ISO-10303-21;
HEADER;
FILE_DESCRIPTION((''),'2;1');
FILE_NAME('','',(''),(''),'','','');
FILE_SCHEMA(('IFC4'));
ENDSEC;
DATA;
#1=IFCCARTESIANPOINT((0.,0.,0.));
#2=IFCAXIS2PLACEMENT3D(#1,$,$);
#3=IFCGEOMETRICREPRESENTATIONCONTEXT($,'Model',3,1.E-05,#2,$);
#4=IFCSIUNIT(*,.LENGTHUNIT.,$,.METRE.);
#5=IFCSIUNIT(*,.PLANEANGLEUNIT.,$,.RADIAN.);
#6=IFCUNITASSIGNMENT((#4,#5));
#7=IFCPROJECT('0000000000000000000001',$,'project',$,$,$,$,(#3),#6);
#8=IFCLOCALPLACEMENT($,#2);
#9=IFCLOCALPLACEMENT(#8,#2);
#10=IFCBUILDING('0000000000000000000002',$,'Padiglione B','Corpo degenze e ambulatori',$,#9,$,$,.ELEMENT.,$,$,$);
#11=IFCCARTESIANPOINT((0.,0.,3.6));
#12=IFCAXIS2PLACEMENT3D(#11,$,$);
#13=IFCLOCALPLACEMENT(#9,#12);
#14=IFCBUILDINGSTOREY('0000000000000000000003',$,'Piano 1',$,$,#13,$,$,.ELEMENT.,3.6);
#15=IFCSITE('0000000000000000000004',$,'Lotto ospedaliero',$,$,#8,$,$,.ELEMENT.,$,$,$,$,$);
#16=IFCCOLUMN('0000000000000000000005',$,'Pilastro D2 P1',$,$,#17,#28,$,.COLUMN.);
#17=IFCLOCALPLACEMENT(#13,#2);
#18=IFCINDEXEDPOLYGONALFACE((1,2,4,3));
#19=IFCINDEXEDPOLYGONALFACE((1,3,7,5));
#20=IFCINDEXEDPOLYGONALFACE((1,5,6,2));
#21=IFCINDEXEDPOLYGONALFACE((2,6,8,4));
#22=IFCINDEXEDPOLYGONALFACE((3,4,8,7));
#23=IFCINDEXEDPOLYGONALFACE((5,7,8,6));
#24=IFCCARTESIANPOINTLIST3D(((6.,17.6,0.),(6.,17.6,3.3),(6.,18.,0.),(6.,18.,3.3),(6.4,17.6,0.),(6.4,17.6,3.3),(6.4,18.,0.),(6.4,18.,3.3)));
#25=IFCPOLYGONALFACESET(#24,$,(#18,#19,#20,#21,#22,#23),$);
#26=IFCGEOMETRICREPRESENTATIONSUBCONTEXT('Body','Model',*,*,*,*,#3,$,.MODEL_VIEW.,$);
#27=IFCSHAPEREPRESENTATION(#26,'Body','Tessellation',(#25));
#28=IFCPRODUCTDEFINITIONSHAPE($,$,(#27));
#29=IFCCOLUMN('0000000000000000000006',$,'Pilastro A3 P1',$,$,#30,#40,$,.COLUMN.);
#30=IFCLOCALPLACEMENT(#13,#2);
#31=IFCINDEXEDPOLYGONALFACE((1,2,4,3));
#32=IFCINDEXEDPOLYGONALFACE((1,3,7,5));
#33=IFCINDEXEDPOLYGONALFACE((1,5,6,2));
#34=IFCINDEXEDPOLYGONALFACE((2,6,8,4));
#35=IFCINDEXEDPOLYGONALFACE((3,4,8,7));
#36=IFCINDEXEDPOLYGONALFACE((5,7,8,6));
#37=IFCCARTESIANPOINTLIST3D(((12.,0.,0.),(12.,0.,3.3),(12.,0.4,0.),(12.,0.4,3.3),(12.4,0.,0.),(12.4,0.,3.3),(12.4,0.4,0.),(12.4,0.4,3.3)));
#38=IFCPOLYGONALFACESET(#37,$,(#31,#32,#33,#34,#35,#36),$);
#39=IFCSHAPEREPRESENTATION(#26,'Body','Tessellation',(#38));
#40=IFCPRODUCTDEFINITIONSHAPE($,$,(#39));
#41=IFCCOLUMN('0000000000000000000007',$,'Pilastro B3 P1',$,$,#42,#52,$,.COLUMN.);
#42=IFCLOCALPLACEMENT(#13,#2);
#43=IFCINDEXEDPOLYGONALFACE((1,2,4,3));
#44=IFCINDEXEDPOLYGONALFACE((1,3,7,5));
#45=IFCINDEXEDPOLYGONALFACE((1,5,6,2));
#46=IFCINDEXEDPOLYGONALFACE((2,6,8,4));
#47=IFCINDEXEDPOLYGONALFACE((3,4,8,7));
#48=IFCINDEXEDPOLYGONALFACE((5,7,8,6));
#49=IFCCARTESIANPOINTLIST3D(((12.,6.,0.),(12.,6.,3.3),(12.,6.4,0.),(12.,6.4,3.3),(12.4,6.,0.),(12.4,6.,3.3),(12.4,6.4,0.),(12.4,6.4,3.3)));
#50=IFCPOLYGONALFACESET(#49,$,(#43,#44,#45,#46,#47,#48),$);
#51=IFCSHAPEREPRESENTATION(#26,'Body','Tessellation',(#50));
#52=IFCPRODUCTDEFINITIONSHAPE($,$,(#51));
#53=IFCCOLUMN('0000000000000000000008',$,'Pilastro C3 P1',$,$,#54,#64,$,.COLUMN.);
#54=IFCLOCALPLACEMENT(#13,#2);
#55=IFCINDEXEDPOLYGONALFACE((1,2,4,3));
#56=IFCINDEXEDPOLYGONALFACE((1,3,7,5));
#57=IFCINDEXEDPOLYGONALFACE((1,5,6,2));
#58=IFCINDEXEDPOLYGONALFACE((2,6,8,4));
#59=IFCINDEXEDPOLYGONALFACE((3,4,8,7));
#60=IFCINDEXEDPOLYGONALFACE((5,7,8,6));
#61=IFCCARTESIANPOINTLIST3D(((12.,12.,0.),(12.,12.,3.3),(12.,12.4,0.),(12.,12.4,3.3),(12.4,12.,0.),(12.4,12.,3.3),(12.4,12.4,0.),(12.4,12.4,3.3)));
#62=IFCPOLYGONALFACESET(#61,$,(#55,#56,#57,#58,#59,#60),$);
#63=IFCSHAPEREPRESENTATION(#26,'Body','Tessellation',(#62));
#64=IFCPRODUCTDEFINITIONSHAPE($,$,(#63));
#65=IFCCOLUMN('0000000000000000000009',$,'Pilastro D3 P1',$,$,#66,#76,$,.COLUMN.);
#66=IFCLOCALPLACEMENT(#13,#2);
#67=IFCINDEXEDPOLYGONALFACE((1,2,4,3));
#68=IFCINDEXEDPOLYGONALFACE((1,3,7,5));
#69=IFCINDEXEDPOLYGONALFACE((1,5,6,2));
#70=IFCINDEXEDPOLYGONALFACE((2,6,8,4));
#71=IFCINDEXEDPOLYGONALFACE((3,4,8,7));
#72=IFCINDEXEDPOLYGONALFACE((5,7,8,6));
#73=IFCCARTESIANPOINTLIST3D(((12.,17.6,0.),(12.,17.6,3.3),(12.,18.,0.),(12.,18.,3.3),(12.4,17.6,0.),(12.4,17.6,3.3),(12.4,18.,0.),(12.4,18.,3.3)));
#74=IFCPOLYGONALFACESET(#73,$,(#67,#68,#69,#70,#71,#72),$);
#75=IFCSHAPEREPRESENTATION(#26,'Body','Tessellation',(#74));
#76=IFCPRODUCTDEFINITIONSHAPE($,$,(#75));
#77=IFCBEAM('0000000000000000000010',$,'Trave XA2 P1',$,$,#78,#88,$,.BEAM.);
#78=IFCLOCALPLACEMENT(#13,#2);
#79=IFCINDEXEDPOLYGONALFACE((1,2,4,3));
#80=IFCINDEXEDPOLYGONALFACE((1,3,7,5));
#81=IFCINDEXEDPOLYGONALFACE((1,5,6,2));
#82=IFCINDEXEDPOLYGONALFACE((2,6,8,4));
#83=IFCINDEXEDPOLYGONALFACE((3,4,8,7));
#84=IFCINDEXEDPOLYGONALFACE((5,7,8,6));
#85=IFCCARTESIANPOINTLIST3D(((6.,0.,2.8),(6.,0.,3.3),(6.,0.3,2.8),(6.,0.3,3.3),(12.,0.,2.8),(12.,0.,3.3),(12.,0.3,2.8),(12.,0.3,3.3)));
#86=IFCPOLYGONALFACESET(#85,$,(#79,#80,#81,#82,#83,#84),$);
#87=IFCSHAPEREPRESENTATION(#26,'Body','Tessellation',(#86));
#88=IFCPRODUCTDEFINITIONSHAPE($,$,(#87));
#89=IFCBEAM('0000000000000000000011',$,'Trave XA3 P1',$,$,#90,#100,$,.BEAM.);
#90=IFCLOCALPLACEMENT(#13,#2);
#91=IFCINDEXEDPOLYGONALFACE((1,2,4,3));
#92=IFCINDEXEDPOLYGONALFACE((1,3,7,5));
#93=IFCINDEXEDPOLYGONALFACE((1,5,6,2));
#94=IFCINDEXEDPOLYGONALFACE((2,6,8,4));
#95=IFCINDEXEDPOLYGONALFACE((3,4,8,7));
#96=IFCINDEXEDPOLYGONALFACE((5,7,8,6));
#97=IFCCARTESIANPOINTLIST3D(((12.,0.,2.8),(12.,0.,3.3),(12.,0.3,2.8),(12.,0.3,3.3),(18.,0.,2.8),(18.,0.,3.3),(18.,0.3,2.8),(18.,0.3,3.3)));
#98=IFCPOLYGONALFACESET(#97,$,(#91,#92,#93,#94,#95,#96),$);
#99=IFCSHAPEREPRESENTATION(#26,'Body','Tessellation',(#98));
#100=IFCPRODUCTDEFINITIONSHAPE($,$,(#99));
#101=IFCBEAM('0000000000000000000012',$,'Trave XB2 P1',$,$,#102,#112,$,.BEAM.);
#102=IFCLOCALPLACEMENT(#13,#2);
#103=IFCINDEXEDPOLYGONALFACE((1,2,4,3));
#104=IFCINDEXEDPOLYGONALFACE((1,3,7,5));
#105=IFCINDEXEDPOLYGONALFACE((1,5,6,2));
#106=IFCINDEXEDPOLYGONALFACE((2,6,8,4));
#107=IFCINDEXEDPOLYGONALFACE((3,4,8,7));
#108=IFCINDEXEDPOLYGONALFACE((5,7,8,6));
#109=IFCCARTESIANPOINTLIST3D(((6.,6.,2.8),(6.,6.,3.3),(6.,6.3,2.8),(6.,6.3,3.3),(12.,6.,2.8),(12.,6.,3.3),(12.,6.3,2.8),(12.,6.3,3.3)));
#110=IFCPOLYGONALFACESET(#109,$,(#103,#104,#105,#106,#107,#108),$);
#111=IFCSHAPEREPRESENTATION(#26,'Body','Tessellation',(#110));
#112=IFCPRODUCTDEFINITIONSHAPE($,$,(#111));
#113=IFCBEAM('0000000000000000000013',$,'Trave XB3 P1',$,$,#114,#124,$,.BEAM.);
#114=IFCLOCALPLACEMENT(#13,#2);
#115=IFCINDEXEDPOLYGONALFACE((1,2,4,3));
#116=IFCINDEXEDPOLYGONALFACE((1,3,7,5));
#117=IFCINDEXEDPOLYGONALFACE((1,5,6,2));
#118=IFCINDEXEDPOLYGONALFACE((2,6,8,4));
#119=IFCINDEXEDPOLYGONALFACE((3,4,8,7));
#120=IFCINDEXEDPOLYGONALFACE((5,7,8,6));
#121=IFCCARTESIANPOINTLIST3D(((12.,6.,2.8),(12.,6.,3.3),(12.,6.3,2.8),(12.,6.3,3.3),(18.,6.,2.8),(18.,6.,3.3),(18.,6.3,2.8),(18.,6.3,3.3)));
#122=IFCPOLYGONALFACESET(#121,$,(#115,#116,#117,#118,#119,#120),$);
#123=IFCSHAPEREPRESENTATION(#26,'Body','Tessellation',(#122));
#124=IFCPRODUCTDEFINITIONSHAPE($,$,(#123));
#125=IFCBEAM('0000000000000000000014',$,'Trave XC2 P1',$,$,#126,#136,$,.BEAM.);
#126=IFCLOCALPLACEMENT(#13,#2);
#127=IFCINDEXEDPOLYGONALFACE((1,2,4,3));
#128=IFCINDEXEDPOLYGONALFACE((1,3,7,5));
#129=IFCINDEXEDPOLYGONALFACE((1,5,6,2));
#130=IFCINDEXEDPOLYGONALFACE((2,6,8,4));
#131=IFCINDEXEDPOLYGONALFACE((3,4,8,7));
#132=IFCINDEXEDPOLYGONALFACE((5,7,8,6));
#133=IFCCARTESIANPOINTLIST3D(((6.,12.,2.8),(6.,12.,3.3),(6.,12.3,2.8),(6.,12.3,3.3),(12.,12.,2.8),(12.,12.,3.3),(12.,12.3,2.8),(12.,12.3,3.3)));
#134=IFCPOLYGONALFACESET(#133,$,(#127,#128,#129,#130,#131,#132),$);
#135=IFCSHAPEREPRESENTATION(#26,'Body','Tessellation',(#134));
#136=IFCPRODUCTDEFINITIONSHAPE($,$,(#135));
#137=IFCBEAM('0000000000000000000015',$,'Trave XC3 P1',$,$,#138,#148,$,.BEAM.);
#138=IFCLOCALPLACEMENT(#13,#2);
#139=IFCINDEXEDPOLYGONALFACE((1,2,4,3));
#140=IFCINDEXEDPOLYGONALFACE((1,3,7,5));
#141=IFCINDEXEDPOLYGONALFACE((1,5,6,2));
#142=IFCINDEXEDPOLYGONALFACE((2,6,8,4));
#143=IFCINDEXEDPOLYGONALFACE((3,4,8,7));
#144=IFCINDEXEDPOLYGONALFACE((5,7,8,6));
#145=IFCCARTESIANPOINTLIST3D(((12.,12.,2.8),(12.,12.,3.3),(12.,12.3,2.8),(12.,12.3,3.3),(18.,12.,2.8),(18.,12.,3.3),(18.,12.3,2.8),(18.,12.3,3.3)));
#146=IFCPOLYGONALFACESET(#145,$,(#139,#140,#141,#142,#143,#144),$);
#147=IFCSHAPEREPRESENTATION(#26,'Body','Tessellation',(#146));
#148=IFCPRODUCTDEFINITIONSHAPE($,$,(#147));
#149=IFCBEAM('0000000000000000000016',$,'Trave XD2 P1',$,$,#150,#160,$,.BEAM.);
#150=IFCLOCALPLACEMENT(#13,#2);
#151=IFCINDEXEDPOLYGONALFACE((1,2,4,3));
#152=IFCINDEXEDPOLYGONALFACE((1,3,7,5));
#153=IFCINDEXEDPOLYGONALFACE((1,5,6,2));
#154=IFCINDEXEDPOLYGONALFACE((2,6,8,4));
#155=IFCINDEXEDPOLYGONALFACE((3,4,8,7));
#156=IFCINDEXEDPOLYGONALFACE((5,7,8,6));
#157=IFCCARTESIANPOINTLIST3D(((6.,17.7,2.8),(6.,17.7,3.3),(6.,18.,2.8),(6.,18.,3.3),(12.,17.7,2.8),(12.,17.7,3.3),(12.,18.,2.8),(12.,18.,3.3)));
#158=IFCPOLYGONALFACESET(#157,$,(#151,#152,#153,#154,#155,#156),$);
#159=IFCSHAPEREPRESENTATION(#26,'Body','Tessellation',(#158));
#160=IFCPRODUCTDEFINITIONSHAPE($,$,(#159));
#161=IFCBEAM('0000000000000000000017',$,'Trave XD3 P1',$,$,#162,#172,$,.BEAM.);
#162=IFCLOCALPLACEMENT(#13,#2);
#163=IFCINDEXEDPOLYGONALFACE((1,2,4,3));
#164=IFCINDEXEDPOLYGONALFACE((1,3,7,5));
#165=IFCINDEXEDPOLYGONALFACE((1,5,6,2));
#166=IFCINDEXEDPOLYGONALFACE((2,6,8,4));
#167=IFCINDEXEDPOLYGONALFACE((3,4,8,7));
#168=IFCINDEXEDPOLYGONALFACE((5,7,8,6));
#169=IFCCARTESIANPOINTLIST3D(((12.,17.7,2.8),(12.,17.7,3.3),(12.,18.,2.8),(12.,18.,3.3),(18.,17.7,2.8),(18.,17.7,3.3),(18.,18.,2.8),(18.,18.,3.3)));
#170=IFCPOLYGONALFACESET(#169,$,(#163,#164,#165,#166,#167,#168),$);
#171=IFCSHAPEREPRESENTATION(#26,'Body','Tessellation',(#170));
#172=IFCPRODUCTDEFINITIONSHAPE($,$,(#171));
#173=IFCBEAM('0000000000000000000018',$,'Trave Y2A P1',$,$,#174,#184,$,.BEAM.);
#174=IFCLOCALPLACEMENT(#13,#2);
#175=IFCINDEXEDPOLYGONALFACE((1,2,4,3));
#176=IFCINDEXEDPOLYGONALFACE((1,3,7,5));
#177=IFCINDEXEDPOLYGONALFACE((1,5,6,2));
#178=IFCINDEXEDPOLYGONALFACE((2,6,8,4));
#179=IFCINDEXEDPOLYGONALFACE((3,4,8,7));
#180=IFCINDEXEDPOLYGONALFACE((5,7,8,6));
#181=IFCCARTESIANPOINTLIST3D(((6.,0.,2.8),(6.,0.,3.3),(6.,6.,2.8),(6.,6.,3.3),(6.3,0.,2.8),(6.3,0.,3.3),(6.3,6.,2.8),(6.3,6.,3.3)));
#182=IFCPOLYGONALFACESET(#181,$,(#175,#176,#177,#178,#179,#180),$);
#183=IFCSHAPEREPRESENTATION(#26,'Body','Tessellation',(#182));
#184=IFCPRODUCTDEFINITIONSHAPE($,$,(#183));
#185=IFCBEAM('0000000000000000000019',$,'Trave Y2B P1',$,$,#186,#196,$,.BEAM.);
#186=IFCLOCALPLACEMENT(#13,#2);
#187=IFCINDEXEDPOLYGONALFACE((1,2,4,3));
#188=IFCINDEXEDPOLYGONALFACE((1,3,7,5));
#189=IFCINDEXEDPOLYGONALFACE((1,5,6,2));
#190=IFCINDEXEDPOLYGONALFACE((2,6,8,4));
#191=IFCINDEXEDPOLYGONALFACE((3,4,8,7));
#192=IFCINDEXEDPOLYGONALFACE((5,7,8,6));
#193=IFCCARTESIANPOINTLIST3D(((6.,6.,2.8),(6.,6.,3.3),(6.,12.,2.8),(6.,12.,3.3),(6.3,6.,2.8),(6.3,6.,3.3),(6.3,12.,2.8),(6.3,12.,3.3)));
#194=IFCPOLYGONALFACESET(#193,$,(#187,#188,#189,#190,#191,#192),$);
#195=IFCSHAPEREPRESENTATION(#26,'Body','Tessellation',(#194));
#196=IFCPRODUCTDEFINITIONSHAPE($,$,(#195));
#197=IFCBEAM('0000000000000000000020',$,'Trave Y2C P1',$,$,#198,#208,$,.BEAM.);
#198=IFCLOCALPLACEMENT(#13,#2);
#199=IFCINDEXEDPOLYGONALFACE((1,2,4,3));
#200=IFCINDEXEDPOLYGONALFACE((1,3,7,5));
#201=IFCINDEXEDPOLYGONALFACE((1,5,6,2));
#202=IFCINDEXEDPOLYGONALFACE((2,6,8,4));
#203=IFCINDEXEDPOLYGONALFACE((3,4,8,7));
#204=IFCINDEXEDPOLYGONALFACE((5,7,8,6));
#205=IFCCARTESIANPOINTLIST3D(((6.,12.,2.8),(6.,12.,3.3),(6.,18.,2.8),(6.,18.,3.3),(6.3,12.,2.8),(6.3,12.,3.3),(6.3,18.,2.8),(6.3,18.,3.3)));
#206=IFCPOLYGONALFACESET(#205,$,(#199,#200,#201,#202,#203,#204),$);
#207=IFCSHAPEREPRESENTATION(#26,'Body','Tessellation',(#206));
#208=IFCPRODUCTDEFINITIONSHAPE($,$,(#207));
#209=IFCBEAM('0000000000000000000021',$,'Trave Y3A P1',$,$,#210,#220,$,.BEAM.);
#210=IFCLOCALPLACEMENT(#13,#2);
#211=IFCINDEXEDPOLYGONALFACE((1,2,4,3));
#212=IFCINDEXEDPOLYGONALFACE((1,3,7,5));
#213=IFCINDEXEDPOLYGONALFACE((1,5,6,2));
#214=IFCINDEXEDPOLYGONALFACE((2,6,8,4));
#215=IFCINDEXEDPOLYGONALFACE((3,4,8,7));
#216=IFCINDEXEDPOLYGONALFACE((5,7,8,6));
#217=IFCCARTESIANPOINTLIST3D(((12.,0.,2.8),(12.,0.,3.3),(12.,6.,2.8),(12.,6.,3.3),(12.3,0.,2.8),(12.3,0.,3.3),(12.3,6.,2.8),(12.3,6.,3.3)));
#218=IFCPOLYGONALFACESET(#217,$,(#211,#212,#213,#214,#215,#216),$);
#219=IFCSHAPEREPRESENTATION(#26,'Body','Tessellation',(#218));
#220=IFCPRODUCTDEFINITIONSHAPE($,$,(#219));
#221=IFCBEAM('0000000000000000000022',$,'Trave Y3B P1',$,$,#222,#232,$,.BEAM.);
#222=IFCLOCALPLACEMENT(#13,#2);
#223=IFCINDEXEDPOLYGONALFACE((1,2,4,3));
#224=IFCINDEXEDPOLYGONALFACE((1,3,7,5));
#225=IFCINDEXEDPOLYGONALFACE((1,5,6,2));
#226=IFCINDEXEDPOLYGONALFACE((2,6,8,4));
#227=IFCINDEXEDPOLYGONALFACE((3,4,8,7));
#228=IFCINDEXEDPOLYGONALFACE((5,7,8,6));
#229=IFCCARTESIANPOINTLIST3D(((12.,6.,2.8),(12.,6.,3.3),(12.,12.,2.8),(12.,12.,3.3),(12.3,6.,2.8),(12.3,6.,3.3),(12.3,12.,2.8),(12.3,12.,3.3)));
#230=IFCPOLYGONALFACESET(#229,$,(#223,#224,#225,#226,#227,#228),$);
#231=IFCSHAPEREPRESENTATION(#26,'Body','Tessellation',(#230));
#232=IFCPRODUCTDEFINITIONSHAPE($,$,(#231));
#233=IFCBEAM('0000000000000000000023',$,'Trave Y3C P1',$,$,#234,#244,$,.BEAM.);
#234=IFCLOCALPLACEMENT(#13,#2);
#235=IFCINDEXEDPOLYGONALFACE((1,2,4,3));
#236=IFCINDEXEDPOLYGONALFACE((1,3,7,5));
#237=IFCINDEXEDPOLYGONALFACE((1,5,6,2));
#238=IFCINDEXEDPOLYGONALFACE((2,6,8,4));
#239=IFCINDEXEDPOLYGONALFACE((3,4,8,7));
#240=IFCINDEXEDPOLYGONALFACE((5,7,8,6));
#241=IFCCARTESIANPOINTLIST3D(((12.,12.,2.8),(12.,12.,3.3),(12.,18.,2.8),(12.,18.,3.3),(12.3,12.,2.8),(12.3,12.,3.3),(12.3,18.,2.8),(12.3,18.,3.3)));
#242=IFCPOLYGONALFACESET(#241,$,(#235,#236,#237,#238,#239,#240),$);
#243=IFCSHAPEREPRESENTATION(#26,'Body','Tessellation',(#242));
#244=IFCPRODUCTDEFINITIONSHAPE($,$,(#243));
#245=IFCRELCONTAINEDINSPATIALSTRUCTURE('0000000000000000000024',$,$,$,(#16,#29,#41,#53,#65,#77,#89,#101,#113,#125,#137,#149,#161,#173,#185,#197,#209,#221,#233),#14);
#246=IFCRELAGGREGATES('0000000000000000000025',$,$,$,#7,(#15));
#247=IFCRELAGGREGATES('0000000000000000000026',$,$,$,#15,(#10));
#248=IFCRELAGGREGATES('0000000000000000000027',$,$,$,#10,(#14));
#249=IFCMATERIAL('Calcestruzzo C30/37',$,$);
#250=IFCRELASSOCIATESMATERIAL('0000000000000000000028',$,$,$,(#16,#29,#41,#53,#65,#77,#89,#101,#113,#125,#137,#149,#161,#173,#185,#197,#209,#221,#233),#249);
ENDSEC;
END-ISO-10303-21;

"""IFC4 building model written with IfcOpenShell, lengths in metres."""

from ifc_helpers import new_model, si_unit, frame, frame_2d, origin, place, context, subcontext, project, spatial, rectangle, extrude, material, element, save


model = new_model("IFC4")

# Units and contexts
model_context = context("Model", 3, precision=1e-05, world=origin())
body_context = subcontext(model_context, "Body", "Model", "MODEL_VIEW")
ifc_project = project(units=[si_unit("LENGTHUNIT", "METRE"), si_unit("PLANEANGLEUNIT", "RADIAN")], contexts=[model_context])

# Site, building, storey
site_placement = place(None, origin())
site = spatial("IfcSite", under=ifc_project, at=site_placement, Name="Lotto ospedaliero", CompositionType="ELEMENT")
building_placement = place(site_placement, origin())
building = spatial("IfcBuilding", under=site, at=building_placement, Name="Padiglione B", Description="Corpo degenze e ambulatori", CompositionType="ELEMENT")
storey_placement = place(building_placement, frame((0.0, 0.0, 3.6)))
storey = spatial("IfcBuildingStorey", under=building, at=storey_placement, Name="Piano 1", CompositionType="ELEMENT", Elevation=3.6)

# Columns
ifc_material_1 = material(Name="Calcestruzzo C30/37")
for number, where, name in (
    (1, (6.0, 17.6, 0.0), "Pilastro D2 P1"),
    (2, (12.0, 0.0, 0.0), "Pilastro A3 P1"),
    (3, (12.0, 6.0, 0.0), "Pilastro B3 P1"),
    (4, (12.0, 12.0, 0.0), "Pilastro C3 P1"),
    (5, (12.0, 17.6, 0.0), "Pilastro D3 P1"),
):
    element("IfcColumn", number, at=place(storey_placement, frame(where)), inside=storey, material=ifc_material_1, Name=name, PredefinedType="COLUMN", context=body_context, shape_type="SweptSolid", body=[
        extrude(rectangle(XDim=0.4, YDim=0.4, at=frame_2d((0.2, 0.2))), origin(), (0.0, 0.0, 1.0), 3.3),
    ])

# Beams
for number, where, name in (
    (6, (6.0, 0.0, 2.8), "Trave XA2 P1"),
    (7, (12.0, 0.0, 2.8), "Trave XA3 P1"),
    (8, (6.0, 6.0, 2.8), "Trave XB2 P1"),
    (9, (12.0, 6.0, 2.8), "Trave XB3 P1"),
    (10, (6.0, 12.0, 2.8), "Trave XC2 P1"),
    (11, (12.0, 12.0, 2.8), "Trave XC3 P1"),
    (12, (6.0, 17.7, 2.8), "Trave XD2 P1"),
    (13, (12.0, 17.7, 2.8), "Trave XD3 P1"),
):
    element("IfcBeam", number, at=place(storey_placement, frame(where)), inside=storey, material=ifc_material_1, Name=name, PredefinedType="BEAM", context=body_context, shape_type="SweptSolid", body=[
        extrude(rectangle(XDim=6.0, YDim=0.3, at=frame_2d((3.0, 0.15))), origin(), (0.0, 0.0, 1.0), 0.5),
    ])
for number, where, name in (
    (14, (6.0, 0.0, 2.8), "Trave Y2A P1"),
    (15, (6.0, 6.0, 2.8), "Trave Y2B P1"),
    (16, (6.0, 12.0, 2.8), "Trave Y2C P1"),
    (17, (12.0, 0.0, 2.8), "Trave Y3A P1"),
    (18, (12.0, 6.0, 2.8), "Trave Y3B P1"),
    (19, (12.0, 12.0, 2.8), "Trave Y3C P1"),
):
    element("IfcBeam", number, at=place(storey_placement, frame(where)), inside=storey, material=ifc_material_1, Name=name, PredefinedType="BEAM", context=body_context, shape_type="SweptSolid", body=[
        extrude(rectangle(XDim=0.3, YDim=6.0, at=frame_2d((0.15, 3.0))), origin(), (0.0, 0.0, 1.0), 0.5),
    ])

save(model, "model.ifc")
